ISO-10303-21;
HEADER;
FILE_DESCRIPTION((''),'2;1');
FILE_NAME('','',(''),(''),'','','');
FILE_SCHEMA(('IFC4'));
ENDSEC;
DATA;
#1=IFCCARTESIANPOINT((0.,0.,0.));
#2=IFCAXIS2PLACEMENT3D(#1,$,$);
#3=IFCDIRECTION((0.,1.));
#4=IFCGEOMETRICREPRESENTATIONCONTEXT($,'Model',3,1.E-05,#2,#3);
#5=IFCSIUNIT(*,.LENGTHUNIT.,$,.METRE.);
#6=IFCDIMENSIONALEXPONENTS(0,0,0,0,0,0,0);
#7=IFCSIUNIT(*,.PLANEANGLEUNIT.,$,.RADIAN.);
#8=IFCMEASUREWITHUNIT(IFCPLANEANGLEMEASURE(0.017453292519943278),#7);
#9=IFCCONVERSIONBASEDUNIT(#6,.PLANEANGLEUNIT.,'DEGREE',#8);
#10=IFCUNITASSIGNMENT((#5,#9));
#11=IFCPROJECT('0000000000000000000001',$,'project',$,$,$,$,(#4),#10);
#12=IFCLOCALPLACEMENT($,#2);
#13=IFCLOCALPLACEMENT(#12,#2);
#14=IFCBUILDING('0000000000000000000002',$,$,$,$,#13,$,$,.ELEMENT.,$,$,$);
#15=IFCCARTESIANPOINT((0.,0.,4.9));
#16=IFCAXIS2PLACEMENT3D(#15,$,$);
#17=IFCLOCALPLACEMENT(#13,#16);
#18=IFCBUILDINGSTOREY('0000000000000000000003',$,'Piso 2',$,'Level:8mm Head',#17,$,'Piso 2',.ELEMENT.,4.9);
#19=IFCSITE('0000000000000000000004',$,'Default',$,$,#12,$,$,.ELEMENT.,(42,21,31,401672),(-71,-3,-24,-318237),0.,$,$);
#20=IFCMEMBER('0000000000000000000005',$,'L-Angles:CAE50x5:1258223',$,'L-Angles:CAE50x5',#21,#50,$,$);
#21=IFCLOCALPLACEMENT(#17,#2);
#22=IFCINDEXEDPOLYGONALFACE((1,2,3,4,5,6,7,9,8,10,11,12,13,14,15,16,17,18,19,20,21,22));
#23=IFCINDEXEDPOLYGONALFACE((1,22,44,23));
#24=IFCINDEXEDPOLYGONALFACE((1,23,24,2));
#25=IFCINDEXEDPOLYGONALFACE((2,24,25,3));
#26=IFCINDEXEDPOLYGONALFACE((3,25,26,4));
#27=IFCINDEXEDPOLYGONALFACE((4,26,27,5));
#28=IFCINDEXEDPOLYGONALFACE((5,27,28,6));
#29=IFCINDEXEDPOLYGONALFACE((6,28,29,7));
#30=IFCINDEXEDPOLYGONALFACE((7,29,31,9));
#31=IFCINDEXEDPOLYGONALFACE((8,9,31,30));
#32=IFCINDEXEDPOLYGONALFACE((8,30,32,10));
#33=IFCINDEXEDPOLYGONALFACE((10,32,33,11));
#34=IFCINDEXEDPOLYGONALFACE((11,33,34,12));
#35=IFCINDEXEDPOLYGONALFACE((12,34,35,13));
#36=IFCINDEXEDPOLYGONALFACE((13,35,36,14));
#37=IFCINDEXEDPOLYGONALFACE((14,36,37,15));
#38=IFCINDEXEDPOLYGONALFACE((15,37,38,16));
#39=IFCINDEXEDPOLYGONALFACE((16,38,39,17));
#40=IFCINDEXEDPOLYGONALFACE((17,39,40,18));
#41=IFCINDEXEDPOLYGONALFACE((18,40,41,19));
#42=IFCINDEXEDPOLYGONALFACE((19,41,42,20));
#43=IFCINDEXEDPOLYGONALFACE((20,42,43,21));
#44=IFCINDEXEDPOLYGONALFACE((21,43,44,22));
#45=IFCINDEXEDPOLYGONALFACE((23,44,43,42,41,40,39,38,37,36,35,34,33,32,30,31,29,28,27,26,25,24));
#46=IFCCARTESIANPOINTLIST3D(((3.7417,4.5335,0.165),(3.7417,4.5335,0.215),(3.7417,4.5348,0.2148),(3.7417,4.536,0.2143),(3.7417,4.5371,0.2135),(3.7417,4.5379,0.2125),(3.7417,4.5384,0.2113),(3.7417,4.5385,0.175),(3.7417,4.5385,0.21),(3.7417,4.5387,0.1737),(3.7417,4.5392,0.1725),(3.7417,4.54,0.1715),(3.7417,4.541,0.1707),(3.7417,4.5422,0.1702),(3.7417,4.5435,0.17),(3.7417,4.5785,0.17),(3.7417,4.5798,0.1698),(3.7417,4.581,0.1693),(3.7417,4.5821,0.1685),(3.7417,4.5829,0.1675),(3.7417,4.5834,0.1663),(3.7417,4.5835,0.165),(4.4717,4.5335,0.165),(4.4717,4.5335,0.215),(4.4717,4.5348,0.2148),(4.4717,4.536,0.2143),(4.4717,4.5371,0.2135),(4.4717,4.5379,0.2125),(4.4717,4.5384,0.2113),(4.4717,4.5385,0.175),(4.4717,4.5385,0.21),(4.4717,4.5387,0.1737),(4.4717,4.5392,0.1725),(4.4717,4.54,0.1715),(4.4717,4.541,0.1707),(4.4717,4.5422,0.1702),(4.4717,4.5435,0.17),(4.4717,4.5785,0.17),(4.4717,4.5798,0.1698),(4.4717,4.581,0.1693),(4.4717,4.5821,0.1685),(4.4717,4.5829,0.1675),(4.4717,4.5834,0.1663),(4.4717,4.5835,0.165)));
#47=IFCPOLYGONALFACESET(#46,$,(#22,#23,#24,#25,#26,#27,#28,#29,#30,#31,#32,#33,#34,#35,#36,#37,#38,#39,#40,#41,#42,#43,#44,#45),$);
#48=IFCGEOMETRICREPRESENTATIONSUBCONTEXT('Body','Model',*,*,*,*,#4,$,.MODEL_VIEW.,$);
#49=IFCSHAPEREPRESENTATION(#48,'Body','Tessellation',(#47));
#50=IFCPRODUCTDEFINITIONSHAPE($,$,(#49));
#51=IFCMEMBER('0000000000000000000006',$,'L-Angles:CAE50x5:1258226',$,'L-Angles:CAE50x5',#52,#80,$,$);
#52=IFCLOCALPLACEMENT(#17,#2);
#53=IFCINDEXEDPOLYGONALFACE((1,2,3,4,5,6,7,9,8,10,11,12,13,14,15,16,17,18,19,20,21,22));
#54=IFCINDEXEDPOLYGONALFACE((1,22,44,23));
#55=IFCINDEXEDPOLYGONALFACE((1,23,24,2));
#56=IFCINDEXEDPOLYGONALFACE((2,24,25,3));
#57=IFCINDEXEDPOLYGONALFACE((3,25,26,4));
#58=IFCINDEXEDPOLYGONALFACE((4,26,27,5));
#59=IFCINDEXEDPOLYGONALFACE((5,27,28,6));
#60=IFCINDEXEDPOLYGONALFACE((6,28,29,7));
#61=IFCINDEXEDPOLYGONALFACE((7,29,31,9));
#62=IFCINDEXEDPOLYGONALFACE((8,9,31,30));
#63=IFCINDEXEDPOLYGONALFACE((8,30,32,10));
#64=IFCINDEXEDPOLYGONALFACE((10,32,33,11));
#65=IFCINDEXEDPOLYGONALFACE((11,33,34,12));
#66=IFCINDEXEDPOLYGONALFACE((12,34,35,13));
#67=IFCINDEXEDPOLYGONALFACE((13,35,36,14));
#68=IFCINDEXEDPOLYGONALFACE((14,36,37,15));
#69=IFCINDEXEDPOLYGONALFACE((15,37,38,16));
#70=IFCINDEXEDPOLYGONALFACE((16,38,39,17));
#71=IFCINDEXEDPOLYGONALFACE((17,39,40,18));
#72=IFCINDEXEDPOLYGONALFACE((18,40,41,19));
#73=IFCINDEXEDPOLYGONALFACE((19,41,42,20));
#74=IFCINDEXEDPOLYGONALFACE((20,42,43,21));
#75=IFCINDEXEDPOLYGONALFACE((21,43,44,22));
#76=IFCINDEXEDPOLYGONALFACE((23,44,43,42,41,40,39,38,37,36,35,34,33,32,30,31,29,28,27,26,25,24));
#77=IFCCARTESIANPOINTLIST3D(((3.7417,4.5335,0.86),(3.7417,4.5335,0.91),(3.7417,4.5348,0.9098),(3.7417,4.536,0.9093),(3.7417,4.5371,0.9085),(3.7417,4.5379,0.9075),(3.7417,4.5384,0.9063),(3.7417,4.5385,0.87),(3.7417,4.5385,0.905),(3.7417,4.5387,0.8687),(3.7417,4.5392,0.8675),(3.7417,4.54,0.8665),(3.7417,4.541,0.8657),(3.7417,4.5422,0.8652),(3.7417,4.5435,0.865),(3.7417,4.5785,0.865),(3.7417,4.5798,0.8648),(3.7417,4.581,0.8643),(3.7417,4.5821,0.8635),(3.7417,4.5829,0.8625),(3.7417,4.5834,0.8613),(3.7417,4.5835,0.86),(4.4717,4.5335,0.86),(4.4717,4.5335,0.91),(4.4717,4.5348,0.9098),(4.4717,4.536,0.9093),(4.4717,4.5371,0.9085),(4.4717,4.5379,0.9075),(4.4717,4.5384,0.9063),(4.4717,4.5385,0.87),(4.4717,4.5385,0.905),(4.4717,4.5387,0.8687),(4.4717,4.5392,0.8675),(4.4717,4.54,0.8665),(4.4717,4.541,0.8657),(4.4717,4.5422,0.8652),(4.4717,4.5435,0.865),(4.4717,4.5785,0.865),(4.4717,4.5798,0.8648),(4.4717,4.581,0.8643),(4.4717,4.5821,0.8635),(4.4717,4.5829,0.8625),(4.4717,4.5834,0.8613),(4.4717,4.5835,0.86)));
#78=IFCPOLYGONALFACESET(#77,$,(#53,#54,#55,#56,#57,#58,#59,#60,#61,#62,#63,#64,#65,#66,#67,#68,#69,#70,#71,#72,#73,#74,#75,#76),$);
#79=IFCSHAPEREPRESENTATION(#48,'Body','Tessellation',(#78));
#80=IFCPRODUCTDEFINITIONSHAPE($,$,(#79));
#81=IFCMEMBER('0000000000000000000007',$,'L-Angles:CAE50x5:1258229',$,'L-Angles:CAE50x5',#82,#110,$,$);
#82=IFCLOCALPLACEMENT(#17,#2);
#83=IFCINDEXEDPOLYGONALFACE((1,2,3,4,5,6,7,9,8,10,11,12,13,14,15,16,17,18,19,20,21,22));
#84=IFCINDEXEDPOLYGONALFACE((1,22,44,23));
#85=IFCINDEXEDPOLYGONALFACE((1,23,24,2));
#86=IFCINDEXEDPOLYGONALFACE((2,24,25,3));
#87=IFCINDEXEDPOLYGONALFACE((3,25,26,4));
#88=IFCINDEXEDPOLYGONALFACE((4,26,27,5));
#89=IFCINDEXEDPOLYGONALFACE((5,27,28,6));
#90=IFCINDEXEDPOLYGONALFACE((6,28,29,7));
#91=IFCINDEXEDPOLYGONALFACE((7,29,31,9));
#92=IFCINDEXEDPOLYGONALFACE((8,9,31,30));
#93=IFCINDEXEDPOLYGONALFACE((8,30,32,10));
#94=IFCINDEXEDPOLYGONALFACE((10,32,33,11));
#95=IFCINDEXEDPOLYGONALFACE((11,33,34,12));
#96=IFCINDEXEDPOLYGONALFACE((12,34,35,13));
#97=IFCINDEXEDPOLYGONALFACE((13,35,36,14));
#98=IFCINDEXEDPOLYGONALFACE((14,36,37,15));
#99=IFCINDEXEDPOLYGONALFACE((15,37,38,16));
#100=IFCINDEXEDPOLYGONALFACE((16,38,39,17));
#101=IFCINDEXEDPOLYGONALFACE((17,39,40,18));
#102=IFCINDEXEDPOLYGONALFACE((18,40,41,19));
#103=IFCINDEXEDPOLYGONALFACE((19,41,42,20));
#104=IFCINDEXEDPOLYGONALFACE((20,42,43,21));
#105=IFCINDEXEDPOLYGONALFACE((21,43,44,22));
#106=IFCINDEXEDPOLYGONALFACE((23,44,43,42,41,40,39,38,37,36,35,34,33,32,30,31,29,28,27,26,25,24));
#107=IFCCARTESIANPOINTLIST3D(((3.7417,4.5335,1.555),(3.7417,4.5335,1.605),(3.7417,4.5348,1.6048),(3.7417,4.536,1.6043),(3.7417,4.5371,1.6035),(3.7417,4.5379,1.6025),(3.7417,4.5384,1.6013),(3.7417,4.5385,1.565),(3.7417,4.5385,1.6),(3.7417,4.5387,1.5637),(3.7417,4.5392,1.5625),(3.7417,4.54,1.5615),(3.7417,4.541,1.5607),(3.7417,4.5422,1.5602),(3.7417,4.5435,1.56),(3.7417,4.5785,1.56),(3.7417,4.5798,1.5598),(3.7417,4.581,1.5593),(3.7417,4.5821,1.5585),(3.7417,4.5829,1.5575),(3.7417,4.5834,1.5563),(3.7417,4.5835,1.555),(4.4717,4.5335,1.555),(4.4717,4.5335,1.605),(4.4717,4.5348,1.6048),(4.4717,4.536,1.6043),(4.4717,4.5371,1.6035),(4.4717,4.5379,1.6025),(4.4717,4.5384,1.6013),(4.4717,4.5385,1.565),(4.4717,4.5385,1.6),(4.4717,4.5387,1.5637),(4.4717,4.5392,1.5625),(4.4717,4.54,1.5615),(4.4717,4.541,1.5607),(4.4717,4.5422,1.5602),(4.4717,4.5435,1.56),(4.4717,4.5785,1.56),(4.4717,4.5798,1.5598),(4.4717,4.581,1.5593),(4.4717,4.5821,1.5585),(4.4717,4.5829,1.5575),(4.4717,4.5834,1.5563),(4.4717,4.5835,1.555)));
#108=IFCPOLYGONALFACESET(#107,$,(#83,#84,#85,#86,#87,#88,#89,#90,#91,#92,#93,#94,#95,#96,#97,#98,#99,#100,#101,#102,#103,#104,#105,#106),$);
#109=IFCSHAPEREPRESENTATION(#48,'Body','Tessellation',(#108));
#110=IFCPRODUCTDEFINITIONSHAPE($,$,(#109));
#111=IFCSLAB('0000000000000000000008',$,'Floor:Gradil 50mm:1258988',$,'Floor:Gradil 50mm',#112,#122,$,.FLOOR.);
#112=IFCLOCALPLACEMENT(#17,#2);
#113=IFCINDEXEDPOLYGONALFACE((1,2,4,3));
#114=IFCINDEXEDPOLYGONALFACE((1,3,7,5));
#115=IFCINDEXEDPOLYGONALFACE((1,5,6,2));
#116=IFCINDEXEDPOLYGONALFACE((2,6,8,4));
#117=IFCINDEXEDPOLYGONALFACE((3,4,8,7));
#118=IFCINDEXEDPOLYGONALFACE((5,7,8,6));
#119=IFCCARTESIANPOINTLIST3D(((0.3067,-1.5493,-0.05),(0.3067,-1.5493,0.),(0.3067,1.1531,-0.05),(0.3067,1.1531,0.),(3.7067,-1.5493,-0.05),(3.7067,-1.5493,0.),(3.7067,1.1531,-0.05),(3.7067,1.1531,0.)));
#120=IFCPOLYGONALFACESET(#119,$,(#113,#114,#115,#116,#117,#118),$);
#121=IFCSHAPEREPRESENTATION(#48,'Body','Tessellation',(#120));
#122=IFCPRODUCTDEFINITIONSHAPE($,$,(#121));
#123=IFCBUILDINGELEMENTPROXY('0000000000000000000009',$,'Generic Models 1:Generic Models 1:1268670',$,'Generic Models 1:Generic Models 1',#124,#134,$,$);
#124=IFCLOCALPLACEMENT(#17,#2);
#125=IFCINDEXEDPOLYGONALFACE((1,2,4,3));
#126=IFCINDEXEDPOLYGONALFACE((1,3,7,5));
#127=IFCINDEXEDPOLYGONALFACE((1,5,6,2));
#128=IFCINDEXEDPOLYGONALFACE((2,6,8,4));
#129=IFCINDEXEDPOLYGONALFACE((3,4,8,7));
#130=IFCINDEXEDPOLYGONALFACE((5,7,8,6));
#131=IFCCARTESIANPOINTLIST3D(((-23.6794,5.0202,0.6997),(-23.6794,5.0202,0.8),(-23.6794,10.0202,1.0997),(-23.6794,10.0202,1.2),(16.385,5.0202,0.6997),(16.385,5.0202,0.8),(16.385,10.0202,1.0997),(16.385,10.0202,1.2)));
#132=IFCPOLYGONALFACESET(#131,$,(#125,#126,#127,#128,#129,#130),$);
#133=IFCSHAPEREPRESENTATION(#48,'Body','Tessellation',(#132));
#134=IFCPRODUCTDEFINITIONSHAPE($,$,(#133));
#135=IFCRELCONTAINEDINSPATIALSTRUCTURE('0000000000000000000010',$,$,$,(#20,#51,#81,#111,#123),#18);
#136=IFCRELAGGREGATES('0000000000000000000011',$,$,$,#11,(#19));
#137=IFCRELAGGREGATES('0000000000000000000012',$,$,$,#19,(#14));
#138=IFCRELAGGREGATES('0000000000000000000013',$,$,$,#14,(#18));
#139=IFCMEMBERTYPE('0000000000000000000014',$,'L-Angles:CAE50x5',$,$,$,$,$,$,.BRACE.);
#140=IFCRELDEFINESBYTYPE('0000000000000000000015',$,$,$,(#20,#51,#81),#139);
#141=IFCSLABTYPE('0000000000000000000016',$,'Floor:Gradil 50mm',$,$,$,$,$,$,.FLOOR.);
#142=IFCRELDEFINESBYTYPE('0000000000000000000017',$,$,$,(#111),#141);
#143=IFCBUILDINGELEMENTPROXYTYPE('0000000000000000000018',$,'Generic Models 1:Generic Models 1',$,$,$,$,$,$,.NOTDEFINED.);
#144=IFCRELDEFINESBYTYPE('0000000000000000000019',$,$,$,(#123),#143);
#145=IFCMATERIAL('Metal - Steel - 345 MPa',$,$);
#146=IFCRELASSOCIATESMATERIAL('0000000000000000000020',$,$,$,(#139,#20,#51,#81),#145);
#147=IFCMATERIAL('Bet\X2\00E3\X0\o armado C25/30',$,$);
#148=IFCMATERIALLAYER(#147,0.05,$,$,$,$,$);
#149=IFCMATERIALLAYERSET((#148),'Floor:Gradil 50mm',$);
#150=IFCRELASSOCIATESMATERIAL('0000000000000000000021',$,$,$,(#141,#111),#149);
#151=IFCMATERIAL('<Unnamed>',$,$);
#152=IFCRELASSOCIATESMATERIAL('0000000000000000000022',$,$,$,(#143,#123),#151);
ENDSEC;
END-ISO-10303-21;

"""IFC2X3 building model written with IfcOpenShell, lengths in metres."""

from ifc_helpers import new_model, entity, si_unit, converted_unit, direction, frame, frame_2d, origin, origin_2d_with_axis, place, context, subcontext, project, spatial, polyline, circle_curve, parameter, trimmed, segment, composite_curve, rectangle, outline, extrude, source, transform, mapped, material, layer, layer_set, layer_usage, type_object, type_shapes, element, save


model = new_model("IFC2X3")

# Units and contexts
model_context = context("Model", 3, precision=1e-05, world=origin(), true_north=direction((0.0, 1.0)))
body_context = subcontext(model_context, "Body", "Model", "MODEL_VIEW")
ifc_project = project(units=[si_unit("LENGTHUNIT", "METRE"), converted_unit("PLANEANGLEUNIT", "DEGREE", entity("IfcPlaneAngleMeasure", 0.017453292519943278), si_unit("PLANEANGLEUNIT", "RADIAN"), dimensions=[0, 0, 0, 0, 0, 0, 0])], contexts=[model_context])

# Site, building, storey
site_placement = place(None, origin())
site = spatial("IfcSite", under=ifc_project, at=site_placement, Name="Default", CompositionType="ELEMENT", RefLatitude=(42, 21, 31, 401672), RefLongitude=(-71, -3, -24, -318237), RefElevation=0.0)
building_placement = place(site_placement, origin())
building = spatial("IfcBuilding", under=site, at=building_placement, CompositionType="ELEMENT")
storey_placement = place(building_placement, frame((0.0, 0.0, 4.9)))
storey = spatial("IfcBuildingStorey", under=building, at=storey_placement, Name="Piso 2", ObjectType="Level:8mm Head", LongName="Piso 2", CompositionType="ELEMENT", Elevation=4.9)

# Shared definitions
ifc_material_1 = material(Name="Metal - Steel - 345 MPa")

# Members
member_type_1 = type_object("IfcMemberType", Name="L-Angles:CAE50x5", PredefinedType="BRACE", material=ifc_material_1)
shared_shape_1 = source(origin(), body_context, "Body", "SweptSolid", [
    extrude(outline(composite_curve([segment(polyline([(-0.0164, -0.0164), (0.0336, -0.0164)]), True, "CONTINUOUS"), segment(trimmed(circle_curve(frame_2d((0.0286, -0.0164), x_axis=(1.0, 0.0)), 0.005), [parameter(0.0)], [parameter(90.0)], True, "PARAMETER"), True, "CONTINUOUS"), segment(polyline([(0.0286, -0.0114), (-0.0064, -0.0114)]), True, "CONTINUOUS"), segment(trimmed(circle_curve(frame_2d((-0.0064, -0.0064), x_axis=(1.0, 0.0)), 0.005), [parameter(180.0)], [parameter(270.0)], True, "PARAMETER"), False, "CONTINUOUS"), segment(polyline([(-0.0114, -0.0064), (-0.0114, 0.0286)]), True, "CONTINUOUS"), segment(trimmed(circle_curve(frame_2d((-0.0164, 0.0286), x_axis=(1.0, 0.0)), 0.005), [parameter(0.0)], [parameter(90.0)], True, "PARAMETER"), True, "CONTINUOUS"), segment(polyline([(-0.0164, 0.0336), (-0.0164, -0.0164)]), True, "CONTINUOUS")], self_intersect=False)), frame((-0.365, -0.0024, -0.0024), z_axis=(1.0, 0.0, 0.0), x_axis=(0.0, -1.0, 0.0)), (0.0, 0.0, 1.0), 0.73),
])
type_shapes(member_type_1, [shared_shape_1])
for number, where, z_axis, x_axis, name in (
    (1, (4.1067, 4.5475, 0.179), (0.0, -1.0, 0.0), (-1.0, 0.0, 0.0), "L-Angles:CAE50x5:1258223"),
    (2, (4.1067, 4.5475, 0.874), (0.0, -1.0, 0.0), (-1.0, 0.0, 0.0), "L-Angles:CAE50x5:1258226"),
    (3, (4.1067, 4.5475, 1.569), (0.0, -1.0, 0.0), (-1.0, 0.0, 0.0), "L-Angles:CAE50x5:1258229"),
):
    element("IfcMember", number, at=place(storey_placement, frame(where, z_axis=z_axis, x_axis=x_axis)), inside=storey, type_object=member_type_1, material=ifc_material_1, Name=name, ObjectType="L-Angles:CAE50x5", context=body_context, shape_type="MappedRepresentation", body=[
        mapped(shared_shape_1, transform((0.0, 0.0, 0.0), scale=1.0)),
    ])

# Slab
ifc_material_2 = material(Name="Betão armado C25/30")
ifc_layer = layer(ifc_material_2, 0.05)
ifc_layer_set = layer_set([ifc_layer], Name="Floor:Gradil 50mm")
ifc_layer_usage = layer_usage(ifc_layer_set, "AXIS3", "POSITIVE", 0.0)
slab_type = type_object("IfcSlabType", Name="Floor:Gradil 50mm", PredefinedType="FLOOR", material=ifc_layer_set)
slab_placement = place(storey_placement, origin())
element("IfcSlab", 4, at=slab_placement, inside=storey, type_object=slab_type, material=ifc_layer_usage, Name="Floor:Gradil 50mm:1258988", ObjectType="Floor:Gradil 50mm", PredefinedType="FLOOR", context=body_context, shape_type="SweptSolid", body=[
    extrude(rectangle(XDim=2.7024, YDim=3.4, at=origin_2d_with_axis()), frame((2.0067, -0.1981, 0.0), z_axis=(0.0, 0.0, -1.0), x_axis=(0.0, 1.0, 0.0)), (0.0, 0.0, 1.0), 0.05),
])

# Building element proxy
ifc_material_3 = material(Name="<Unnamed>")
building_element_proxy_type_1 = type_object("IfcBuildingElementProxyType", Name="Generic Models 1:Generic Models 1", PredefinedType="NOTDEFINED", material=ifc_material_3)
shared_shape_2 = source(origin(), body_context, "Body", "SweptSolid", [
    extrude(outline(polyline([(-2.512, -0.05), (2.504, -0.05), (2.512, 0.05), (-2.504, 0.05), (-2.512, -0.05)])), frame((-23.6794, 7.5202, 5.8498), z_axis=(1.0, 0.0, 0.0), x_axis=(0.0, -0.996815, -0.079745)), (0.0, 0.0, 1.0), 40.0644),
])
type_shapes(building_element_proxy_type_1, [shared_shape_2])
proxy_1_placement = place(storey_placement, frame((0.0, 0.0, -4.9)))
element("IfcBuildingElementProxy", 5, at=proxy_1_placement, inside=storey, type_object=building_element_proxy_type_1, material=ifc_material_3, Name="Generic Models 1:Generic Models 1:1268670", ObjectType="Generic Models 1:Generic Models 1", context=body_context, shape_type="MappedRepresentation", body=[
    mapped(shared_shape_2, transform((0.0, 0.0, 0.0), scale=1.0)),
])

save(model, "model.ifc")
